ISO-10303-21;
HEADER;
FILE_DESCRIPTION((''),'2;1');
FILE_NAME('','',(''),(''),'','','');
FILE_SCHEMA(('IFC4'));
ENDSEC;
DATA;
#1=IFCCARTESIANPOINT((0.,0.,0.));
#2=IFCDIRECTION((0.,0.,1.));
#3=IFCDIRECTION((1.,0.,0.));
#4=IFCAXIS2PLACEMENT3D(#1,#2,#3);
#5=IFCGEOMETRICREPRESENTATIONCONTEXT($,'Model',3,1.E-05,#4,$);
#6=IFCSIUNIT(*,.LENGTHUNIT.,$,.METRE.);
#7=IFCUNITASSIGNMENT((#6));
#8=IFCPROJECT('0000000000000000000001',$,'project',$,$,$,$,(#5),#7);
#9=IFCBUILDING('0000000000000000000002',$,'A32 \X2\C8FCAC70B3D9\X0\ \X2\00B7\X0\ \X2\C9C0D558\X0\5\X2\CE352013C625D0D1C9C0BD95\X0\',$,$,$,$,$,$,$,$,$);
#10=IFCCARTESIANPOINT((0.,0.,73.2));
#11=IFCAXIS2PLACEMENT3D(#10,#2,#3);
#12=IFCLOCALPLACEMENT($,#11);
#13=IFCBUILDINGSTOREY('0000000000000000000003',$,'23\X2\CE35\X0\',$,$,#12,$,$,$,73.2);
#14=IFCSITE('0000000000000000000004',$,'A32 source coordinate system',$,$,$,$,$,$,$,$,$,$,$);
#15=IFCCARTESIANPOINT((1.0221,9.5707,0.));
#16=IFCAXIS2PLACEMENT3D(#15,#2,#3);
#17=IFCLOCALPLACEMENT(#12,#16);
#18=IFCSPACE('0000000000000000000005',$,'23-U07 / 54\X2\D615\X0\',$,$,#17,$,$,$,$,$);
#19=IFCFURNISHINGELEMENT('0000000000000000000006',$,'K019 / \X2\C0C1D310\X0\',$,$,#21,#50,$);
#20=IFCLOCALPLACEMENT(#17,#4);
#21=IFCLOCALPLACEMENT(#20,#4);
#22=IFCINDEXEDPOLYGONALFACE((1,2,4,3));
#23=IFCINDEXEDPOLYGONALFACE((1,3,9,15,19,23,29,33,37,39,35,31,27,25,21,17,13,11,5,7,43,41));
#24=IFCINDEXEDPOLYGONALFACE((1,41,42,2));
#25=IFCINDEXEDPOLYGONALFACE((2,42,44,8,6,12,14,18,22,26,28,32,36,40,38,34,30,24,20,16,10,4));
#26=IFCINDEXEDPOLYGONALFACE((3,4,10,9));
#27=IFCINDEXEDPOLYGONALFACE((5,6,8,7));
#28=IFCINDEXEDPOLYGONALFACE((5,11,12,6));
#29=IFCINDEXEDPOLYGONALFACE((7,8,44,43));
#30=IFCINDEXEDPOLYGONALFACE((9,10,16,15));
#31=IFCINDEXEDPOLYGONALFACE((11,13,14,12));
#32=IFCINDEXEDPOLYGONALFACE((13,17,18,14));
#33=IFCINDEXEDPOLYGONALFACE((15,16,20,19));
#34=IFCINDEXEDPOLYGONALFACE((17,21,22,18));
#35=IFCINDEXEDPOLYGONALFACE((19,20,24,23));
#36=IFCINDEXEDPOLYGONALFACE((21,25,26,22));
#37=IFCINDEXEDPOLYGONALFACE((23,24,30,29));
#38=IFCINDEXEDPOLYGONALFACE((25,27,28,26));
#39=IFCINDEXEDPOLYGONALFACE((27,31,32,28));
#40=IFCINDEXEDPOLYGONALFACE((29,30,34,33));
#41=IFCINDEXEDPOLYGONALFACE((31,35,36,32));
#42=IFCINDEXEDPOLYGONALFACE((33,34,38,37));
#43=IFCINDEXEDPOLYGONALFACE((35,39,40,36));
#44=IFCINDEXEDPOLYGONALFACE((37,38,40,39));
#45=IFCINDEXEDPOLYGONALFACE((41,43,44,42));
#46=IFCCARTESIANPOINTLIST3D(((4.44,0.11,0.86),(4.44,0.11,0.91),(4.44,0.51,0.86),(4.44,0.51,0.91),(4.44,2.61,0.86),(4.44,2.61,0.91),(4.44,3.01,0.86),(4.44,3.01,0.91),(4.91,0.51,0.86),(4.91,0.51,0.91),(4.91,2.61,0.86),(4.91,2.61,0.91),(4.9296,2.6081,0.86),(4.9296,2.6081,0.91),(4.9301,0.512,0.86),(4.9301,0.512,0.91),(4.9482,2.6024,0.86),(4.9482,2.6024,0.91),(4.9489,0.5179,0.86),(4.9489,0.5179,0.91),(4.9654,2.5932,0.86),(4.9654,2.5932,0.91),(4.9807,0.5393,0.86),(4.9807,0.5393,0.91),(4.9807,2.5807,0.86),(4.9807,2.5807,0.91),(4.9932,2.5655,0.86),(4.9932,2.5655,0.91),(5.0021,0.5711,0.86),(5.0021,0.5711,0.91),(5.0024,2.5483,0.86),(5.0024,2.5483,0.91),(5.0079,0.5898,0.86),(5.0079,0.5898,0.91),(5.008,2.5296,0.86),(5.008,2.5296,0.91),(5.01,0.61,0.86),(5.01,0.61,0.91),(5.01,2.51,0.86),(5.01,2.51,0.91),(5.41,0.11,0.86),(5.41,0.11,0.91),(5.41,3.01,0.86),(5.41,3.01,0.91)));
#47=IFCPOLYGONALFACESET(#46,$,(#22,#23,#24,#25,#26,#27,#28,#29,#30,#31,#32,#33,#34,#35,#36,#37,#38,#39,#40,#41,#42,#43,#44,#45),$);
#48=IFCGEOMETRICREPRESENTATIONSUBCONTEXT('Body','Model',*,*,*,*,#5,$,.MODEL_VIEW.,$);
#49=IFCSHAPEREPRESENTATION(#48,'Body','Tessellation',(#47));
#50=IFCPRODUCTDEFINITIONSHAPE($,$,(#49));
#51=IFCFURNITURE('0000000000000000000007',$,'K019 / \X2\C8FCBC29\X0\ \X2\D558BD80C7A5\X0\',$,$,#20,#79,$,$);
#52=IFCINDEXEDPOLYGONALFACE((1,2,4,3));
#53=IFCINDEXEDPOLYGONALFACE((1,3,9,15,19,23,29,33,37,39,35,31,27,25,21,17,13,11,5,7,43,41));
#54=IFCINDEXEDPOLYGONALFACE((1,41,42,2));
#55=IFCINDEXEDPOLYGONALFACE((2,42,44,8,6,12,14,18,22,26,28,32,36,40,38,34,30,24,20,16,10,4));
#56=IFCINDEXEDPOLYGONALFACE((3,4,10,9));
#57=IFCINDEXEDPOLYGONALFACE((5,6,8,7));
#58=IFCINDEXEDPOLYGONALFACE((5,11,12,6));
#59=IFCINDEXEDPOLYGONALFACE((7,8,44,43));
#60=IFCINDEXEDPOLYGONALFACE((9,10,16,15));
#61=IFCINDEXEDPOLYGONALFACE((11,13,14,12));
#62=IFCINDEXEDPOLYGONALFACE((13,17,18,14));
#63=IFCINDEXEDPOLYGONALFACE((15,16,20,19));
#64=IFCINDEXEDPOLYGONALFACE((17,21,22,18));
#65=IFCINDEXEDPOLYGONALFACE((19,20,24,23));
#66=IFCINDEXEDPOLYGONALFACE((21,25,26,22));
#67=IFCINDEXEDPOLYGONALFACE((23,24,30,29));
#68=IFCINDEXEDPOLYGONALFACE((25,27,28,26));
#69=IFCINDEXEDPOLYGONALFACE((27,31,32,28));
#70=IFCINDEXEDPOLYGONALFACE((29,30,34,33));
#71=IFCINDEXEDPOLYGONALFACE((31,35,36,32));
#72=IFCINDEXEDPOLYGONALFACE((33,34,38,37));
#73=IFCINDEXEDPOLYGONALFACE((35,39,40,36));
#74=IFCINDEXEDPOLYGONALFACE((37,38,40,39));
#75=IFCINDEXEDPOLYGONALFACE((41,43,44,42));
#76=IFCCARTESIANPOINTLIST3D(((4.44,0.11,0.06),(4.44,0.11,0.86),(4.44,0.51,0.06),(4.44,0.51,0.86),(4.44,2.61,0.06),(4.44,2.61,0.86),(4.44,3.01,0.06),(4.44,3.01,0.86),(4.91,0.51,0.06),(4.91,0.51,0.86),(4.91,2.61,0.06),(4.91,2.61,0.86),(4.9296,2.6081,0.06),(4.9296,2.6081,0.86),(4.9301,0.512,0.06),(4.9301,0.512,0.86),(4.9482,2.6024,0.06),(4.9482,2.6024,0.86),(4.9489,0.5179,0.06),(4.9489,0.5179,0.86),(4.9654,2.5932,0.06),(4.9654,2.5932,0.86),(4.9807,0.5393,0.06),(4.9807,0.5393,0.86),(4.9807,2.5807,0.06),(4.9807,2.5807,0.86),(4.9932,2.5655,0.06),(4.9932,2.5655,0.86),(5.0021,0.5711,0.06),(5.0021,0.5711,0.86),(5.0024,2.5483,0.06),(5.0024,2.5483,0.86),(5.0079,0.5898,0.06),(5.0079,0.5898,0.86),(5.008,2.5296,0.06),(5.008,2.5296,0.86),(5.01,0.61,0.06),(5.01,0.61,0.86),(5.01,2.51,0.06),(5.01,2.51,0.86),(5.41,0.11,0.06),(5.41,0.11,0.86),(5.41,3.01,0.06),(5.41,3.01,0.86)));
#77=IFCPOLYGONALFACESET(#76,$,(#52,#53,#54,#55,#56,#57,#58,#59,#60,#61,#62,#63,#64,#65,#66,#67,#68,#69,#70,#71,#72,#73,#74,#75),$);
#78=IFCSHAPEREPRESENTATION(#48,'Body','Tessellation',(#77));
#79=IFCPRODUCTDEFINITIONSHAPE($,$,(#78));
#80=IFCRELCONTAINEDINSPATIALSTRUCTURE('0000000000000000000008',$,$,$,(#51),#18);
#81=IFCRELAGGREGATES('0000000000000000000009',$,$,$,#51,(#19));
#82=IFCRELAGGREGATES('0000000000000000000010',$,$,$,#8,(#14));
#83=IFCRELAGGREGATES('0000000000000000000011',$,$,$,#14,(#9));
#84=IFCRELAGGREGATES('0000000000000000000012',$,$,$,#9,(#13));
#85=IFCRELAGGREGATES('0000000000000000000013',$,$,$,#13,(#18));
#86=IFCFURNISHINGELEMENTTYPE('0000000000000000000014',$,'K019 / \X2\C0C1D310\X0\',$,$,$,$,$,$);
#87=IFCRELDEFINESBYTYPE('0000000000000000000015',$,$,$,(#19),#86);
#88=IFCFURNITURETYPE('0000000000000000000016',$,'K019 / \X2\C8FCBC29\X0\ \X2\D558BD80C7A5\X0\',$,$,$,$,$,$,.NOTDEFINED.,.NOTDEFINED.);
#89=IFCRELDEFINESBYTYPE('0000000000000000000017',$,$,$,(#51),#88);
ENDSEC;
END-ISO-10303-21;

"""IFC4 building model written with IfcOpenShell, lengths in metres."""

from ifc_helpers import new_model, si_unit, frame, origin, origin_with_axes, place, context, subcontext, project, spatial, polyline, outline, extrude, source, transform, mapped, type_object, type_shapes, element, aggregate, save


model = new_model("IFC4")

# Units and contexts
model_context = context("Model", 3, precision=1e-05, world=origin_with_axes())
body_context = subcontext(model_context, "Body", "Model", "MODEL_VIEW")
ifc_project = project(units=[si_unit("LENGTHUNIT", "METRE")], contexts=[model_context])

# Site, building, storey, space
site = spatial("IfcSite", under=ifc_project, Name="A32 source coordinate system")
building = spatial("IfcBuilding", under=site, Name="A32 주거동 · 지하5층–옥탑지붕")
storey_placement = place(None, frame((0.0, 0.0, 73.2), z_axis=(0.0, 0.0, 1.0), x_axis=(1.0, 0.0, 0.0)))
storey = spatial("IfcBuildingStorey", under=building, at=storey_placement, Name="23층", Elevation=73.2)
space_1_placement = place(storey_placement, frame((1.0221, 9.5707, 0.0), z_axis=(0.0, 0.0, 1.0), x_axis=(1.0, 0.0, 0.0)))
space_1 = spatial("IfcSpace", under=storey, at=space_1_placement, Name="23-U07 / 54형")

# Furnishing element
furnishing_element_type_1 = type_object("IfcFurnishingElementType", Name="K019 / 상판")
shared_shape_1 = source(origin(), body_context, "Body", "SweptSolid", [
    extrude(outline(polyline([(4.91, 0.51), (4.9301, 0.512), (4.9489, 0.5179), (4.9807, 0.5393), (5.0021, 0.5711), (5.0079, 0.5898), (5.01, 0.61), (5.01, 2.51), (5.008, 2.5296), (5.0024, 2.5483), (4.9932, 2.5655), (4.9807, 2.5807), (4.9654, 2.5932), (4.9482, 2.6024), (4.9296, 2.6081), (4.91, 2.61), (4.44, 2.61), (4.44, 3.01), (5.41, 3.01), (5.41, 0.11), (4.44, 0.11), (4.44, 0.51), (4.91, 0.51)])), frame((0.0, 0.0, 0.86)), (0.0, 0.0, 1.0), 0.05),
])
type_shapes(furnishing_element_type_1, [shared_shape_1])
furniture_1_placement = place(space_1_placement, origin_with_axes())
furnishing_1_placement = place(furniture_1_placement, origin_with_axes())
furnishing_1 = element("IfcFurnishingElement", 1, at=furnishing_1_placement, type_object=furnishing_element_type_1, Name="K019 / 상판", context=body_context, shape_type="MappedRepresentation", body=[
    mapped(shared_shape_1, transform((0.0, 0.0, 0.0), scale=1.0)),
])

# Furniture
furniture_type_1 = type_object("IfcFurnitureType", Name="K019 / 주방 하부장", AssemblyPlace="NOTDEFINED", PredefinedType="NOTDEFINED")
shared_shape_2 = source(origin(), body_context, "Body", "SweptSolid", [
    extrude(outline(polyline([(4.44, 0.51), (4.91, 0.51), (4.9301, 0.512), (4.9489, 0.5179), (4.9807, 0.5393), (5.0021, 0.5711), (5.0079, 0.5898), (5.01, 0.61), (5.01, 2.51), (5.008, 2.5296), (5.0024, 2.5483), (4.9932, 2.5655), (4.9807, 2.5807), (4.9654, 2.5932), (4.9482, 2.6024), (4.9296, 2.6081), (4.91, 2.61), (4.44, 2.61), (4.44, 3.01), (5.41, 3.01), (5.41, 0.11), (4.44, 0.11), (4.44, 0.51)])), frame((0.0, 0.0, 0.06)), (0.0, 0.0, 1.0), 0.8),
])
type_shapes(furniture_type_1, [shared_shape_2])
furniture_1 = element("IfcFurniture", 2, at=furniture_1_placement, inside=space_1, type_object=furniture_type_1, Name="K019 / 주방 하부장", context=body_context, shape_type="MappedRepresentation", body=[
    mapped(shared_shape_2, transform((0.0, 0.0, 0.0), scale=1.0)),
])
aggregate(furniture_1, [furnishing_1])

save(model, "model.ifc")
